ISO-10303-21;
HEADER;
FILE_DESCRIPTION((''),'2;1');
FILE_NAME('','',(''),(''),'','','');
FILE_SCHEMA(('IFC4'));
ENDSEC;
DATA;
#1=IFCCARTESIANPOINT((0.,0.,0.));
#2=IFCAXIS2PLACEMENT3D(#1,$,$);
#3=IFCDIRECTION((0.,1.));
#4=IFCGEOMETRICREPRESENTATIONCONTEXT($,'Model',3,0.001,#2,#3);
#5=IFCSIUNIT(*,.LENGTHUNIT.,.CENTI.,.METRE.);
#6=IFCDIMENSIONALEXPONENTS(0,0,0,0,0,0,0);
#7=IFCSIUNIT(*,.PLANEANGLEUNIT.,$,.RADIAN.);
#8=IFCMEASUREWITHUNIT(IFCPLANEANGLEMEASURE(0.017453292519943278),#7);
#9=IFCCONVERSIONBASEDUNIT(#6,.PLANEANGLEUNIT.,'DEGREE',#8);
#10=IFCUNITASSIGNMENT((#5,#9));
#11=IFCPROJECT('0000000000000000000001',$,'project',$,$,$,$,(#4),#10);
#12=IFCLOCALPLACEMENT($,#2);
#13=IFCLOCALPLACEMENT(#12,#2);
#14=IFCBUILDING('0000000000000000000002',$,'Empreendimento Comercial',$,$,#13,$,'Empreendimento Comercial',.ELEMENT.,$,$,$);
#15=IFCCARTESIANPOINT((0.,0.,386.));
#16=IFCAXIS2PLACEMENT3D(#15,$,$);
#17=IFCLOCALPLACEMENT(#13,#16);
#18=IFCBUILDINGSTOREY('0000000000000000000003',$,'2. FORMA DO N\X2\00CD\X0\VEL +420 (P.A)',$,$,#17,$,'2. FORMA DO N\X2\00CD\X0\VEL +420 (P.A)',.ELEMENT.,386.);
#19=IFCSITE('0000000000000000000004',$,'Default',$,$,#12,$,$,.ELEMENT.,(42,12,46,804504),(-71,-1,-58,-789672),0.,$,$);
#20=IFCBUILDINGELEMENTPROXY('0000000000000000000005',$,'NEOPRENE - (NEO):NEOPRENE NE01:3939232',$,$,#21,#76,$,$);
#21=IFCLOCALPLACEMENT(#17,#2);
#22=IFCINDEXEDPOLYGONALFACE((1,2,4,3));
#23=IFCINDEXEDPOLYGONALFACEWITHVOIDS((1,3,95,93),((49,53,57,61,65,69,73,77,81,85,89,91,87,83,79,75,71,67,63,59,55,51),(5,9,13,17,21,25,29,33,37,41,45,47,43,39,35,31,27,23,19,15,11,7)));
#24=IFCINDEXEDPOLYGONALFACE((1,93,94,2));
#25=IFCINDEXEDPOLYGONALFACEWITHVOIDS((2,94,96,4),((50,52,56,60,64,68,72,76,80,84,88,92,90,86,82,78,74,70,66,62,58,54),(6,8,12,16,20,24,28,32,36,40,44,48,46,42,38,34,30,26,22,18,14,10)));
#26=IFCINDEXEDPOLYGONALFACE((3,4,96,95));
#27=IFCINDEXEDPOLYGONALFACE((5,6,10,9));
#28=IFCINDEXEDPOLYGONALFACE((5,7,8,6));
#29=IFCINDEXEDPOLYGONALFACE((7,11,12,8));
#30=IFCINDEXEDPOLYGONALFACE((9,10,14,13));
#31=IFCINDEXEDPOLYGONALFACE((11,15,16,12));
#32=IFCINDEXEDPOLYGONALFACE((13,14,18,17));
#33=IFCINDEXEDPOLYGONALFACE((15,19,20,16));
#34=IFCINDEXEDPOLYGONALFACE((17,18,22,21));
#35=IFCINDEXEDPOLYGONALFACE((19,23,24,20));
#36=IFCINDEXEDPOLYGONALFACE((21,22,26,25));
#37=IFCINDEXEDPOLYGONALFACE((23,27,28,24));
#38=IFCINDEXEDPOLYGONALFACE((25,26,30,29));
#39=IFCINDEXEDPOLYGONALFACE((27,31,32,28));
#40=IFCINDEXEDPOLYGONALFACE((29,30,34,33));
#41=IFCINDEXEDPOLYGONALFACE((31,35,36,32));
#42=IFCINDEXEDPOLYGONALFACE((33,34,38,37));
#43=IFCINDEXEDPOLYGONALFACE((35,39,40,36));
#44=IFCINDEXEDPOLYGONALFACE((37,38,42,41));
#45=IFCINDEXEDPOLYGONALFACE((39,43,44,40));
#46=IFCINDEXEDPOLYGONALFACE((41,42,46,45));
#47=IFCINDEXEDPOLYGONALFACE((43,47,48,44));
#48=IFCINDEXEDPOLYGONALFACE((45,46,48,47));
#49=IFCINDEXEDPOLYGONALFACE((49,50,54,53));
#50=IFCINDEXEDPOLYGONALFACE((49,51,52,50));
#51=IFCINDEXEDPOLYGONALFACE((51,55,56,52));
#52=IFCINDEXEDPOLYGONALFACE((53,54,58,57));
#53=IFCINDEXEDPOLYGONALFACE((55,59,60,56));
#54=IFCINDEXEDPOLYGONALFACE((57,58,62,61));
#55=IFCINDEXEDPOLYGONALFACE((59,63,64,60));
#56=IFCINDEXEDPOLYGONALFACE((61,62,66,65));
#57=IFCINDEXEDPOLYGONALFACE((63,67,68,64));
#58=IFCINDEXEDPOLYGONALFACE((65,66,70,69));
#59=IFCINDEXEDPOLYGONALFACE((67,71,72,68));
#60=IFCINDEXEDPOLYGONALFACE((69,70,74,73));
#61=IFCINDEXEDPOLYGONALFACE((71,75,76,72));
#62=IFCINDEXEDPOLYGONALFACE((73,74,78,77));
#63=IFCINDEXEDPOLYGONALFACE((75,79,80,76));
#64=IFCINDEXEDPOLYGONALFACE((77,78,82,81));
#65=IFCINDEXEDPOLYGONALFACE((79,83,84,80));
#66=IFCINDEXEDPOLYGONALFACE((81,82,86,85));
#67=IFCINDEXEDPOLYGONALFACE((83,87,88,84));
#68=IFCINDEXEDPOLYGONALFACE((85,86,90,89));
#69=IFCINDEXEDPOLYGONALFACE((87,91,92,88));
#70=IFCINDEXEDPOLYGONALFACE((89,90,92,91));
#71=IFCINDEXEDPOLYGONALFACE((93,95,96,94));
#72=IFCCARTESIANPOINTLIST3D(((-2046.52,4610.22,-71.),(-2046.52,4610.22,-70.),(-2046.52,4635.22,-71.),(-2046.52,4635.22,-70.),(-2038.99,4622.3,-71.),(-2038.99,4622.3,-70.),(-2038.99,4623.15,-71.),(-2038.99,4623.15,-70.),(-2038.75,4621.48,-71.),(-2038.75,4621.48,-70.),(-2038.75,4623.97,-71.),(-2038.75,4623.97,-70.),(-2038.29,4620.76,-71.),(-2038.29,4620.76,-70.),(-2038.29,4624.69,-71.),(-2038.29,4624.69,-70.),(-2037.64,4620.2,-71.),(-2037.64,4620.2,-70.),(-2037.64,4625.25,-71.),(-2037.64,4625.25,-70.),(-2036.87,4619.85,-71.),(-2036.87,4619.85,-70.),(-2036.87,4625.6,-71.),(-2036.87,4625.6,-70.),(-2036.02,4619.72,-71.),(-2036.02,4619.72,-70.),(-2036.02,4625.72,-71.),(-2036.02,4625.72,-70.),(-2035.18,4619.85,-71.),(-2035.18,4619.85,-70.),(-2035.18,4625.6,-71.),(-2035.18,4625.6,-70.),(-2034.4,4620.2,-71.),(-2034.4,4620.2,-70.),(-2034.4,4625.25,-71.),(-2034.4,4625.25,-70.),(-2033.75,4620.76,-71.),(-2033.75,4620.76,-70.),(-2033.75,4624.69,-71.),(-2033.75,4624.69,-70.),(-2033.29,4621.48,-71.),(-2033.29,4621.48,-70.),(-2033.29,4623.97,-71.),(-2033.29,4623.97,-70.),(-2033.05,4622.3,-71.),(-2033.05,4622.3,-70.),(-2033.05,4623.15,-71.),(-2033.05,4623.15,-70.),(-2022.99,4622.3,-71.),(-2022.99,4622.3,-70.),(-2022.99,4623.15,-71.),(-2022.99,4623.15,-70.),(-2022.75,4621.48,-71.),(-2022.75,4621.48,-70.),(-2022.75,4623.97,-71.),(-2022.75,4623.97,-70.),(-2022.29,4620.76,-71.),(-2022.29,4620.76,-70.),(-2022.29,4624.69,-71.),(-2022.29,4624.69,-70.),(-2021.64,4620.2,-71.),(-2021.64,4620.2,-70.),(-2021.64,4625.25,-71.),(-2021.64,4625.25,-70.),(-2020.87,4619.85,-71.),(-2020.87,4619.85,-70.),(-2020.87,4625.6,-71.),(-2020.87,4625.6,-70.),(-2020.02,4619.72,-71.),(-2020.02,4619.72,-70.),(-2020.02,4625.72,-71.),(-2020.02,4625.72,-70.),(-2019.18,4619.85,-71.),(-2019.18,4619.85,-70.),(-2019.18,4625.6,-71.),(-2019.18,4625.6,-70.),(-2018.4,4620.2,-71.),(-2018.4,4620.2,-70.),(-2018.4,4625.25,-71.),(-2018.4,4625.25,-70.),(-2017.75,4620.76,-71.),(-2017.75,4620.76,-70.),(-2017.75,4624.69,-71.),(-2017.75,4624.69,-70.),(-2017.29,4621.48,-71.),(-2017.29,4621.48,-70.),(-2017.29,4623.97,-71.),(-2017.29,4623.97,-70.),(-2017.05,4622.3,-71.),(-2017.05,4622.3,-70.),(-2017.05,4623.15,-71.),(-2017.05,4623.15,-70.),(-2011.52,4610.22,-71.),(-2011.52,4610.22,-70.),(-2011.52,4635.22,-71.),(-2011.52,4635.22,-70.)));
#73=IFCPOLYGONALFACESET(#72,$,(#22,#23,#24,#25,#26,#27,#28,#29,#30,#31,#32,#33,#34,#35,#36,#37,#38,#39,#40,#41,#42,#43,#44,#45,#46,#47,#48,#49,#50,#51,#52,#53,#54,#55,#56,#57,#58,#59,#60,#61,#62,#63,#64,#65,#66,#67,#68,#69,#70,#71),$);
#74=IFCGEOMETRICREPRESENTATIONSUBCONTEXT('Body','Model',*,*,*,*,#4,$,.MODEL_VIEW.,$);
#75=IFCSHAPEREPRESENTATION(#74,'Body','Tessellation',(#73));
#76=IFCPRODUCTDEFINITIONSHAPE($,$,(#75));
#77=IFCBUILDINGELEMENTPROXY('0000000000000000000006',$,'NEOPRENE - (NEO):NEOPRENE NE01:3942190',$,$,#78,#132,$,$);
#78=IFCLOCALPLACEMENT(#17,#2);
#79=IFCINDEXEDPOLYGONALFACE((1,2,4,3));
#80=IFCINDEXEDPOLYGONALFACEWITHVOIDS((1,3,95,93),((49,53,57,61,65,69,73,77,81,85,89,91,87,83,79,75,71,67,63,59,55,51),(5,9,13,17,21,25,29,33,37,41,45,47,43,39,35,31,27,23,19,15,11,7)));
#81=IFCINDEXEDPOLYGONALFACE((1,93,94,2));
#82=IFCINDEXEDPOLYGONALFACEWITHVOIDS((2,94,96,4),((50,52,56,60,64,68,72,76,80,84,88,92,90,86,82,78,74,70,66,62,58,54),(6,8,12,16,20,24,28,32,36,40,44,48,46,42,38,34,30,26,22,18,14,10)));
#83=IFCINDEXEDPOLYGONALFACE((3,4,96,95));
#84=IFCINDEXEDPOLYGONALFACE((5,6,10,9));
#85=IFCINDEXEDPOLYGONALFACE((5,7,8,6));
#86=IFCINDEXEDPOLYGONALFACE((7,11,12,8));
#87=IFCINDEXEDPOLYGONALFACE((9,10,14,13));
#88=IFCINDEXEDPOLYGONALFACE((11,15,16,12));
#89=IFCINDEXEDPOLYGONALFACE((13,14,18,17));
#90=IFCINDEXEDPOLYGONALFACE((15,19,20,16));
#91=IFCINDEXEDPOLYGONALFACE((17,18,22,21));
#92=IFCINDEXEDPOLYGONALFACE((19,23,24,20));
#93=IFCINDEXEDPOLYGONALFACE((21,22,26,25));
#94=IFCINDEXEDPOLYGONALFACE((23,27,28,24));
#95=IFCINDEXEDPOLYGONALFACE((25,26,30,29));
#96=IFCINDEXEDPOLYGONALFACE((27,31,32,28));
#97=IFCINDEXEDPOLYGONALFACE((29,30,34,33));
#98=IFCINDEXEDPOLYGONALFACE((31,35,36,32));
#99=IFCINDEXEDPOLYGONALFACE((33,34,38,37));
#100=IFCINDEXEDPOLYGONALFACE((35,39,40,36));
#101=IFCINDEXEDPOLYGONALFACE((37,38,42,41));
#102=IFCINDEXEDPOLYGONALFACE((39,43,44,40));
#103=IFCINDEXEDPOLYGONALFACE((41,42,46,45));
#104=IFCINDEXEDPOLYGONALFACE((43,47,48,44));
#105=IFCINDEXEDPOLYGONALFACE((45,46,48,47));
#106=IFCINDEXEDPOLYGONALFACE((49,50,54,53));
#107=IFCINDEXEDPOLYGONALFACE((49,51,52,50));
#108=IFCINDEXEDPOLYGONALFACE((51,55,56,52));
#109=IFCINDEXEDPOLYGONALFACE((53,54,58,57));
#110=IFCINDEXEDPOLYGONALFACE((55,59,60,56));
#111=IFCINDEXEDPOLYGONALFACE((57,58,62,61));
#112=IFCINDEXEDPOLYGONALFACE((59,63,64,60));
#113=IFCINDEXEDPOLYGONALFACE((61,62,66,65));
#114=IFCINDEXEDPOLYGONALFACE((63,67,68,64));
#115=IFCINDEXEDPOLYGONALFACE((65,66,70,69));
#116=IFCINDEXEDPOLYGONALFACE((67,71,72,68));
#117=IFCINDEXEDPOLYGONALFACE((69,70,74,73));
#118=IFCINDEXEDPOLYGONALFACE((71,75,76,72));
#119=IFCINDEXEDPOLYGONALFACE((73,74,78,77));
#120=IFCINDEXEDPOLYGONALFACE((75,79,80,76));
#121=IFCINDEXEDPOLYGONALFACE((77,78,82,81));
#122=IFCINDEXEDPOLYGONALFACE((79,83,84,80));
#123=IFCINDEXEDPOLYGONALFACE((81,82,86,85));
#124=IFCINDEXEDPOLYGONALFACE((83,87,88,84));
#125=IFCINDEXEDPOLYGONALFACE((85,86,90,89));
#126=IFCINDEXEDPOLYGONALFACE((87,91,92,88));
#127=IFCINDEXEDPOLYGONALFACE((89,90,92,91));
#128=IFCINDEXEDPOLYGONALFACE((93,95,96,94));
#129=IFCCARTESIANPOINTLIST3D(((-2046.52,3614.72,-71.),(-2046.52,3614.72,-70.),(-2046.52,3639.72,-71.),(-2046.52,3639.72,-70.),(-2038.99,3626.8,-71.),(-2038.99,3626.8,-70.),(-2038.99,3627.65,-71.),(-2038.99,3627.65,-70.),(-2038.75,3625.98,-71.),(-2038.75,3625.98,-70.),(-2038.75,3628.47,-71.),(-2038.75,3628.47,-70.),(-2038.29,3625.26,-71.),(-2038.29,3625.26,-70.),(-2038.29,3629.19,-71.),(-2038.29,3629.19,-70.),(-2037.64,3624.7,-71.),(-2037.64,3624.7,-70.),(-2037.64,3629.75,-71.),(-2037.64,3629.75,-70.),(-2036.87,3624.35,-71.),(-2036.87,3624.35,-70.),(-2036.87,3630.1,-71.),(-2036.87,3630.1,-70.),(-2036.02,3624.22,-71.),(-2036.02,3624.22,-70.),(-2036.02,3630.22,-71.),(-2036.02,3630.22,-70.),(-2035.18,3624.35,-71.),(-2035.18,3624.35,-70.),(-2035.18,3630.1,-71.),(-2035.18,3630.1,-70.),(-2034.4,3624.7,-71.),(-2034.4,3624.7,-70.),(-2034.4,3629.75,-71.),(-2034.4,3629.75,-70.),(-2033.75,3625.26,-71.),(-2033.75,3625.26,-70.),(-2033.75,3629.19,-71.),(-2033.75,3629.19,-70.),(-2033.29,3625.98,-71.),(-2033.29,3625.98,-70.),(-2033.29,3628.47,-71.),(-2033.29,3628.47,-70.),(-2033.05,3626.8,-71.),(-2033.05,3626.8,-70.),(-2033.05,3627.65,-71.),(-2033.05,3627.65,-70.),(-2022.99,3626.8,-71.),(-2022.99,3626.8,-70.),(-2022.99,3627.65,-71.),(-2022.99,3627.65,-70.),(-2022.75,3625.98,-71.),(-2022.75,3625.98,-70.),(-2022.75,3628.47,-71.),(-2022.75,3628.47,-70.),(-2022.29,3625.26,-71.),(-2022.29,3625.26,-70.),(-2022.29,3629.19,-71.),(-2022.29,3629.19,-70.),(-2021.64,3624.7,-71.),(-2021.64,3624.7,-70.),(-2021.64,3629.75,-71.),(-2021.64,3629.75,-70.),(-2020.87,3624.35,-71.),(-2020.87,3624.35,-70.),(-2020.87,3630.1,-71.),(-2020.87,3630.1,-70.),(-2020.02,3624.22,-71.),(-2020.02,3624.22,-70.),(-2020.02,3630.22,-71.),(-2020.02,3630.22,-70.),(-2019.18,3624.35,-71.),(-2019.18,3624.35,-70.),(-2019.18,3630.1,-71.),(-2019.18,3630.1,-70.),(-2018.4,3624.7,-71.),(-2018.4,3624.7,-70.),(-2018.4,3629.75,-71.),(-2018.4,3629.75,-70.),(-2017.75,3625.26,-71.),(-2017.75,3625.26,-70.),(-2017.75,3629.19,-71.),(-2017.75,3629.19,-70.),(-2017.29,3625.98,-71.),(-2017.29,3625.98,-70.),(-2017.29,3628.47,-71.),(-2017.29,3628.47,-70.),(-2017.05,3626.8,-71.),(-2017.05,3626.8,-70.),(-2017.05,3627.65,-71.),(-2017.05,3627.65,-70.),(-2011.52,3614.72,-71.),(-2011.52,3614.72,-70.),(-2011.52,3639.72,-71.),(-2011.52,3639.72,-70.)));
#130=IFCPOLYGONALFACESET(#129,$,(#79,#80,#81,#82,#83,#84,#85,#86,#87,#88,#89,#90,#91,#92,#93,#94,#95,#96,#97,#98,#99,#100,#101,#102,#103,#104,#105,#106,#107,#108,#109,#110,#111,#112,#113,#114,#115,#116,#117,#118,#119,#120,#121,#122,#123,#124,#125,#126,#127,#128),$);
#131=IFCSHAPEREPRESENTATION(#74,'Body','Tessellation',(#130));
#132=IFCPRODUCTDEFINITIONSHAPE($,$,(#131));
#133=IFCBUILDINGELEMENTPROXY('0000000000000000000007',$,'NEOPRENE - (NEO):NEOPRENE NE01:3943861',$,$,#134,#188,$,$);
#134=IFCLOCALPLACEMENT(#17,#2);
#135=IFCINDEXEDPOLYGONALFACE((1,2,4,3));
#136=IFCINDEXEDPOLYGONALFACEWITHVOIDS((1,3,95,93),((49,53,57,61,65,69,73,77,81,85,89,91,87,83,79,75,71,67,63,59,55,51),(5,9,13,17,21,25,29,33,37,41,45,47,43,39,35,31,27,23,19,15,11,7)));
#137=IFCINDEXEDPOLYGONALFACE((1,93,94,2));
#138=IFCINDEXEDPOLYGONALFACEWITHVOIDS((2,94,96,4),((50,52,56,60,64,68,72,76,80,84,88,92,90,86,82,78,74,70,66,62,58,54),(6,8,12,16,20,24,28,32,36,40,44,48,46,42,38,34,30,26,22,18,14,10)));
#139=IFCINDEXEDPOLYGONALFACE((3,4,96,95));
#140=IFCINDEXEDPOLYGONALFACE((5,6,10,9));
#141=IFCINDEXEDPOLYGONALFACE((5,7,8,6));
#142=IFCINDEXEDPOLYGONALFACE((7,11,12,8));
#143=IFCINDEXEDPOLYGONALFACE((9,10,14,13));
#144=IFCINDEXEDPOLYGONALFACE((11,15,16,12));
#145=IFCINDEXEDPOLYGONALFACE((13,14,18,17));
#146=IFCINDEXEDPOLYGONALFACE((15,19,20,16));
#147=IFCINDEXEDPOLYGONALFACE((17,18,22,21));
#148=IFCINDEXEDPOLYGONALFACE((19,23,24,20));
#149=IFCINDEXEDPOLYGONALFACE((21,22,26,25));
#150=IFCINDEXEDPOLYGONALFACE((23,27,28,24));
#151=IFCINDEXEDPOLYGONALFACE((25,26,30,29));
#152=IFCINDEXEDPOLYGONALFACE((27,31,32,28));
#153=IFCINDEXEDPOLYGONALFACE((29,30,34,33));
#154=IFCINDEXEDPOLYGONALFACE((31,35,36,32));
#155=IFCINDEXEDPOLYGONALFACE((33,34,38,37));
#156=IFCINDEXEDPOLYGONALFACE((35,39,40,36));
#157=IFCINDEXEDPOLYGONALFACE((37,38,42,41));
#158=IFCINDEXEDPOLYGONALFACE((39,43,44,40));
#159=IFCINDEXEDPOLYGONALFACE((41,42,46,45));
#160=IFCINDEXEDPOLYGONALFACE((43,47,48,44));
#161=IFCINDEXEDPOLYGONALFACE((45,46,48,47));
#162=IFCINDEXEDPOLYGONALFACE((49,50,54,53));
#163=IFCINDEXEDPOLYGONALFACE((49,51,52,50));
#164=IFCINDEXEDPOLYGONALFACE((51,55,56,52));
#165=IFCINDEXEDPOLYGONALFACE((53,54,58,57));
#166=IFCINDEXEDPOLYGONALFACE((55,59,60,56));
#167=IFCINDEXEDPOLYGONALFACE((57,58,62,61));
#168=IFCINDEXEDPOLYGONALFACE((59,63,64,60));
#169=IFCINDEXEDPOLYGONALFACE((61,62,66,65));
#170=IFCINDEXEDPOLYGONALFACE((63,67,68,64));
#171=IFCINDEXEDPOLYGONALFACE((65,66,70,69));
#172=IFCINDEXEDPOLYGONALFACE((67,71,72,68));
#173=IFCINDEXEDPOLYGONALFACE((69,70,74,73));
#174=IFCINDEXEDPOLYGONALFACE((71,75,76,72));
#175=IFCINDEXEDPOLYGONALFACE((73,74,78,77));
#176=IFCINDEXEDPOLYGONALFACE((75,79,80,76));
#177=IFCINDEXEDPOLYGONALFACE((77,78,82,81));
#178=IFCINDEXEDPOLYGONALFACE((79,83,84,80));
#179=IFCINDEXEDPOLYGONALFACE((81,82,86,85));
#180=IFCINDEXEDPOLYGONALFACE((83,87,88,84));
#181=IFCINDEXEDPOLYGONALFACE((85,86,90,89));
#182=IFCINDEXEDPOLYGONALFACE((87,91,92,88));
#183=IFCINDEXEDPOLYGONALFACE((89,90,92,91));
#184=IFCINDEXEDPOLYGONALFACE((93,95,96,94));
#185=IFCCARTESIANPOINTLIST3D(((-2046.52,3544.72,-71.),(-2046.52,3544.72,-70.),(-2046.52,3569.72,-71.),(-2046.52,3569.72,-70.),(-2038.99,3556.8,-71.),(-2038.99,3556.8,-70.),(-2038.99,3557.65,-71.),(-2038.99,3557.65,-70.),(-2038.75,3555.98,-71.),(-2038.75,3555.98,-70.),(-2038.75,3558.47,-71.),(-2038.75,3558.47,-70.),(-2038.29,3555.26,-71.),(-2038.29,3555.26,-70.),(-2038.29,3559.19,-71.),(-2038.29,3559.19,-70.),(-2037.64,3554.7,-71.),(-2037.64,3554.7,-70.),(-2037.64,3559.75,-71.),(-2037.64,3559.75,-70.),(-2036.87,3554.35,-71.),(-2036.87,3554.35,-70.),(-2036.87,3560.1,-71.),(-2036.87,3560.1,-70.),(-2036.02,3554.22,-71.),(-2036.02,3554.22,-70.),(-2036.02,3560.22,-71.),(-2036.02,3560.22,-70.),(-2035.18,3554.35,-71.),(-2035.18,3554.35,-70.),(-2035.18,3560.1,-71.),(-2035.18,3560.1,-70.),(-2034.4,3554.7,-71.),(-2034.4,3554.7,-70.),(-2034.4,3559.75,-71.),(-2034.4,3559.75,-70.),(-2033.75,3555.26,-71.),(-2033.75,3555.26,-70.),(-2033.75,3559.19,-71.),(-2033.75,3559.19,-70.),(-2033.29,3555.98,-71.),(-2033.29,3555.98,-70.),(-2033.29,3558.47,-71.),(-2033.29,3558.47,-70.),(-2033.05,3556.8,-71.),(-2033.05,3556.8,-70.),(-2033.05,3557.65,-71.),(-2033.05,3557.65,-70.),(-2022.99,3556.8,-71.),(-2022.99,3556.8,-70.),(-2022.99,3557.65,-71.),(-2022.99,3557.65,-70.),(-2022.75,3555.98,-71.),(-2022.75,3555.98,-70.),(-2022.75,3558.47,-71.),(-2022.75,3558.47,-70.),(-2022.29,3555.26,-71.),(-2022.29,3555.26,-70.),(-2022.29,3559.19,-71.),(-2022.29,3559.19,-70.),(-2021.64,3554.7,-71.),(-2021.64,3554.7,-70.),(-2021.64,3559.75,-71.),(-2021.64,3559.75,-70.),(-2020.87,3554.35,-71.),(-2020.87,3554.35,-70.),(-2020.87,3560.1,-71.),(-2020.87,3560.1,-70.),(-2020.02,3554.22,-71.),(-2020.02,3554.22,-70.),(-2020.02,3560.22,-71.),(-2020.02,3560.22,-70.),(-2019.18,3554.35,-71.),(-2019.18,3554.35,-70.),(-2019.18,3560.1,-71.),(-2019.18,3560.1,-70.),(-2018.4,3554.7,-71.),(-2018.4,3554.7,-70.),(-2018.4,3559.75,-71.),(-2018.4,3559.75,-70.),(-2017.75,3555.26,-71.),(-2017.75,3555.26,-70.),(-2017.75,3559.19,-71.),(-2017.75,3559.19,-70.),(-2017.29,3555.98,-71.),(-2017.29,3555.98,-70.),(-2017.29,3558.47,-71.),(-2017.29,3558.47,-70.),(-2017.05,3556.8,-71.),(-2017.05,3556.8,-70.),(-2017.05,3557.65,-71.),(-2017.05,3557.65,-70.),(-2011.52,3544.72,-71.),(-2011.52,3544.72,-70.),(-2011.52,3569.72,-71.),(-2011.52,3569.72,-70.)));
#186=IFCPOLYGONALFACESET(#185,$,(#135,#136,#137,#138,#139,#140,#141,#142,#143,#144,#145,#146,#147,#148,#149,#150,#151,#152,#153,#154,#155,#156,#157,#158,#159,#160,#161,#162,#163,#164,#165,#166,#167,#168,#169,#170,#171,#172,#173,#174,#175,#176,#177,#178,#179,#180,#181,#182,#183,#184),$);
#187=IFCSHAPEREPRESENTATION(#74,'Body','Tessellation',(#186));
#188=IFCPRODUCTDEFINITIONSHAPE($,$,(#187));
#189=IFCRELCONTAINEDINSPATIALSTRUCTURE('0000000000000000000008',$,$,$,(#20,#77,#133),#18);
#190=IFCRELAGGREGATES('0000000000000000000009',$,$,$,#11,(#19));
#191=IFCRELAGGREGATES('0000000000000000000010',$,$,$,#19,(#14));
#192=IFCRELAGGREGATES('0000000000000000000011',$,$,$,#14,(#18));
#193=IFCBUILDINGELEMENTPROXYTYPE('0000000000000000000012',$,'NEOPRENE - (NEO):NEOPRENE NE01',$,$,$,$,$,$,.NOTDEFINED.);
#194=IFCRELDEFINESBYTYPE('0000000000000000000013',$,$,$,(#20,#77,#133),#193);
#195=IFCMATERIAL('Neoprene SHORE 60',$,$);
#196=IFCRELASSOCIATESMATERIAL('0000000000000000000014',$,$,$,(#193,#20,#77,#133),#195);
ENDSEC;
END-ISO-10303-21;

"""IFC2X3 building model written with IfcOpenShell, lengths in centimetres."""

from ifc_helpers import new_model, entity, si_unit, converted_unit, direction, frame, frame_2d, origin, place, context, subcontext, project, spatial, polyline, circle_curve, parameter, trimmed, segment, composite_curve, outline, extrude, source, transform, mapped, material, type_object, type_shapes, element, save


model = new_model("IFC2X3")

# Units and contexts
model_context = context("Model", 3, precision=0.001, world=origin(), true_north=direction((0.0, 1.0)))
body_context = subcontext(model_context, "Body", "Model", "MODEL_VIEW")
ifc_project = project(units=[si_unit("LENGTHUNIT", "METRE", prefix="CENTI"), converted_unit("PLANEANGLEUNIT", "DEGREE", entity("IfcPlaneAngleMeasure", 0.017453292519943278), si_unit("PLANEANGLEUNIT", "RADIAN"), dimensions=[0, 0, 0, 0, 0, 0, 0])], contexts=[model_context])

# Site, building, storey
site_placement = place(None, origin())
site = spatial("IfcSite", under=ifc_project, at=site_placement, Name="Default", CompositionType="ELEMENT", RefLatitude=(42, 12, 46, 804504), RefLongitude=(-71, -1, -58, -789672), RefElevation=0.0)
building_placement = place(site_placement, origin())
building = spatial("IfcBuilding", under=site, at=building_placement, Name="Empreendimento Comercial", LongName="Empreendimento Comercial", CompositionType="ELEMENT")
storey_placement = place(building_placement, frame((0.0, 0.0, 386.0)))
storey = spatial("IfcBuildingStorey", under=building, at=storey_placement, Name="2. FORMA DO NÍVEL +420 (P.A)", LongName="2. FORMA DO NÍVEL +420 (P.A)", CompositionType="ELEMENT", Elevation=386.0)

# Building element proxies
ifc_material = material(Name="Neoprene SHORE 60")
building_element_proxy_type_1 = type_object("IfcBuildingElementProxyType", Name="NEOPRENE - (NEO):NEOPRENE NE01", PredefinedType="NOTDEFINED", material=ifc_material)
shared_shape_1 = source(origin(), body_context, "Body", "SweptSolid", [
    extrude(outline(polyline([(-17.5, -12.5), (17.5, -12.5), (17.5, 12.5), (-17.5, 12.5), (-17.5, -12.5)]), holes=[composite_curve([segment(trimmed(circle_curve(frame_2d((-9.0, 0.0), x_axis=(0.0, -1.0)), 3.0), [parameter(0.0)], [parameter(180.0)], True, "PARAMETER"), False, "CONTINUOUS"), segment(trimmed(circle_curve(frame_2d((-9.0, 0.0), x_axis=(0.0, -1.0)), 3.0), [parameter(180.0)], [parameter(0.0)], True, "PARAMETER"), False, "CONTINUOUS")], self_intersect=False), composite_curve([segment(trimmed(circle_curve(frame_2d((7.0, 0.0), x_axis=(0.0, -1.0)), 3.0), [parameter(0.0)], [parameter(180.0)], True, "PARAMETER"), False, "CONTINUOUS"), segment(trimmed(circle_curve(frame_2d((7.0, 0.0), x_axis=(0.0, -1.0)), 3.0), [parameter(180.0)], [parameter(0.0)], True, "PARAMETER"), False, "CONTINUOUS")], self_intersect=False)]), frame((0.0, 0.0, -71.0), z_axis=(0.0, 0.0, 1.0), x_axis=(0.0, 1.0, 0.0)), (0.0, 0.0, 1.0), 1.0),
])
type_shapes(building_element_proxy_type_1, [shared_shape_1])
for number, where, z_axis, x_axis, name in (
    (1, (-2029.02, 4622.72, 0.0), (0.0, 0.0, 1.0), (0.0, 1.0, 0.0), "NEOPRENE - (NEO):NEOPRENE NE01:3939232"),
    (2, (-2029.02, 3627.22, 0.0), (0.0, 0.0, 1.0), (0.0, 1.0, 0.0), "NEOPRENE - (NEO):NEOPRENE NE01:3942190"),
    (3, (-2029.02, 3557.22, 0.0), (0.0, 0.0, 1.0), (0.0, 1.0, 0.0), "NEOPRENE - (NEO):NEOPRENE NE01:3943861"),
):
    element("IfcBuildingElementProxy", number, at=place(storey_placement, frame(where, z_axis=z_axis, x_axis=x_axis)), inside=storey, type_object=building_element_proxy_type_1, material=ifc_material, Name=name, context=body_context, shape_type="MappedRepresentation", body=[
        mapped(shared_shape_1, transform((0.0, 0.0, 0.0), scale=1.0)),
    ])

save(model, "model.ifc")
